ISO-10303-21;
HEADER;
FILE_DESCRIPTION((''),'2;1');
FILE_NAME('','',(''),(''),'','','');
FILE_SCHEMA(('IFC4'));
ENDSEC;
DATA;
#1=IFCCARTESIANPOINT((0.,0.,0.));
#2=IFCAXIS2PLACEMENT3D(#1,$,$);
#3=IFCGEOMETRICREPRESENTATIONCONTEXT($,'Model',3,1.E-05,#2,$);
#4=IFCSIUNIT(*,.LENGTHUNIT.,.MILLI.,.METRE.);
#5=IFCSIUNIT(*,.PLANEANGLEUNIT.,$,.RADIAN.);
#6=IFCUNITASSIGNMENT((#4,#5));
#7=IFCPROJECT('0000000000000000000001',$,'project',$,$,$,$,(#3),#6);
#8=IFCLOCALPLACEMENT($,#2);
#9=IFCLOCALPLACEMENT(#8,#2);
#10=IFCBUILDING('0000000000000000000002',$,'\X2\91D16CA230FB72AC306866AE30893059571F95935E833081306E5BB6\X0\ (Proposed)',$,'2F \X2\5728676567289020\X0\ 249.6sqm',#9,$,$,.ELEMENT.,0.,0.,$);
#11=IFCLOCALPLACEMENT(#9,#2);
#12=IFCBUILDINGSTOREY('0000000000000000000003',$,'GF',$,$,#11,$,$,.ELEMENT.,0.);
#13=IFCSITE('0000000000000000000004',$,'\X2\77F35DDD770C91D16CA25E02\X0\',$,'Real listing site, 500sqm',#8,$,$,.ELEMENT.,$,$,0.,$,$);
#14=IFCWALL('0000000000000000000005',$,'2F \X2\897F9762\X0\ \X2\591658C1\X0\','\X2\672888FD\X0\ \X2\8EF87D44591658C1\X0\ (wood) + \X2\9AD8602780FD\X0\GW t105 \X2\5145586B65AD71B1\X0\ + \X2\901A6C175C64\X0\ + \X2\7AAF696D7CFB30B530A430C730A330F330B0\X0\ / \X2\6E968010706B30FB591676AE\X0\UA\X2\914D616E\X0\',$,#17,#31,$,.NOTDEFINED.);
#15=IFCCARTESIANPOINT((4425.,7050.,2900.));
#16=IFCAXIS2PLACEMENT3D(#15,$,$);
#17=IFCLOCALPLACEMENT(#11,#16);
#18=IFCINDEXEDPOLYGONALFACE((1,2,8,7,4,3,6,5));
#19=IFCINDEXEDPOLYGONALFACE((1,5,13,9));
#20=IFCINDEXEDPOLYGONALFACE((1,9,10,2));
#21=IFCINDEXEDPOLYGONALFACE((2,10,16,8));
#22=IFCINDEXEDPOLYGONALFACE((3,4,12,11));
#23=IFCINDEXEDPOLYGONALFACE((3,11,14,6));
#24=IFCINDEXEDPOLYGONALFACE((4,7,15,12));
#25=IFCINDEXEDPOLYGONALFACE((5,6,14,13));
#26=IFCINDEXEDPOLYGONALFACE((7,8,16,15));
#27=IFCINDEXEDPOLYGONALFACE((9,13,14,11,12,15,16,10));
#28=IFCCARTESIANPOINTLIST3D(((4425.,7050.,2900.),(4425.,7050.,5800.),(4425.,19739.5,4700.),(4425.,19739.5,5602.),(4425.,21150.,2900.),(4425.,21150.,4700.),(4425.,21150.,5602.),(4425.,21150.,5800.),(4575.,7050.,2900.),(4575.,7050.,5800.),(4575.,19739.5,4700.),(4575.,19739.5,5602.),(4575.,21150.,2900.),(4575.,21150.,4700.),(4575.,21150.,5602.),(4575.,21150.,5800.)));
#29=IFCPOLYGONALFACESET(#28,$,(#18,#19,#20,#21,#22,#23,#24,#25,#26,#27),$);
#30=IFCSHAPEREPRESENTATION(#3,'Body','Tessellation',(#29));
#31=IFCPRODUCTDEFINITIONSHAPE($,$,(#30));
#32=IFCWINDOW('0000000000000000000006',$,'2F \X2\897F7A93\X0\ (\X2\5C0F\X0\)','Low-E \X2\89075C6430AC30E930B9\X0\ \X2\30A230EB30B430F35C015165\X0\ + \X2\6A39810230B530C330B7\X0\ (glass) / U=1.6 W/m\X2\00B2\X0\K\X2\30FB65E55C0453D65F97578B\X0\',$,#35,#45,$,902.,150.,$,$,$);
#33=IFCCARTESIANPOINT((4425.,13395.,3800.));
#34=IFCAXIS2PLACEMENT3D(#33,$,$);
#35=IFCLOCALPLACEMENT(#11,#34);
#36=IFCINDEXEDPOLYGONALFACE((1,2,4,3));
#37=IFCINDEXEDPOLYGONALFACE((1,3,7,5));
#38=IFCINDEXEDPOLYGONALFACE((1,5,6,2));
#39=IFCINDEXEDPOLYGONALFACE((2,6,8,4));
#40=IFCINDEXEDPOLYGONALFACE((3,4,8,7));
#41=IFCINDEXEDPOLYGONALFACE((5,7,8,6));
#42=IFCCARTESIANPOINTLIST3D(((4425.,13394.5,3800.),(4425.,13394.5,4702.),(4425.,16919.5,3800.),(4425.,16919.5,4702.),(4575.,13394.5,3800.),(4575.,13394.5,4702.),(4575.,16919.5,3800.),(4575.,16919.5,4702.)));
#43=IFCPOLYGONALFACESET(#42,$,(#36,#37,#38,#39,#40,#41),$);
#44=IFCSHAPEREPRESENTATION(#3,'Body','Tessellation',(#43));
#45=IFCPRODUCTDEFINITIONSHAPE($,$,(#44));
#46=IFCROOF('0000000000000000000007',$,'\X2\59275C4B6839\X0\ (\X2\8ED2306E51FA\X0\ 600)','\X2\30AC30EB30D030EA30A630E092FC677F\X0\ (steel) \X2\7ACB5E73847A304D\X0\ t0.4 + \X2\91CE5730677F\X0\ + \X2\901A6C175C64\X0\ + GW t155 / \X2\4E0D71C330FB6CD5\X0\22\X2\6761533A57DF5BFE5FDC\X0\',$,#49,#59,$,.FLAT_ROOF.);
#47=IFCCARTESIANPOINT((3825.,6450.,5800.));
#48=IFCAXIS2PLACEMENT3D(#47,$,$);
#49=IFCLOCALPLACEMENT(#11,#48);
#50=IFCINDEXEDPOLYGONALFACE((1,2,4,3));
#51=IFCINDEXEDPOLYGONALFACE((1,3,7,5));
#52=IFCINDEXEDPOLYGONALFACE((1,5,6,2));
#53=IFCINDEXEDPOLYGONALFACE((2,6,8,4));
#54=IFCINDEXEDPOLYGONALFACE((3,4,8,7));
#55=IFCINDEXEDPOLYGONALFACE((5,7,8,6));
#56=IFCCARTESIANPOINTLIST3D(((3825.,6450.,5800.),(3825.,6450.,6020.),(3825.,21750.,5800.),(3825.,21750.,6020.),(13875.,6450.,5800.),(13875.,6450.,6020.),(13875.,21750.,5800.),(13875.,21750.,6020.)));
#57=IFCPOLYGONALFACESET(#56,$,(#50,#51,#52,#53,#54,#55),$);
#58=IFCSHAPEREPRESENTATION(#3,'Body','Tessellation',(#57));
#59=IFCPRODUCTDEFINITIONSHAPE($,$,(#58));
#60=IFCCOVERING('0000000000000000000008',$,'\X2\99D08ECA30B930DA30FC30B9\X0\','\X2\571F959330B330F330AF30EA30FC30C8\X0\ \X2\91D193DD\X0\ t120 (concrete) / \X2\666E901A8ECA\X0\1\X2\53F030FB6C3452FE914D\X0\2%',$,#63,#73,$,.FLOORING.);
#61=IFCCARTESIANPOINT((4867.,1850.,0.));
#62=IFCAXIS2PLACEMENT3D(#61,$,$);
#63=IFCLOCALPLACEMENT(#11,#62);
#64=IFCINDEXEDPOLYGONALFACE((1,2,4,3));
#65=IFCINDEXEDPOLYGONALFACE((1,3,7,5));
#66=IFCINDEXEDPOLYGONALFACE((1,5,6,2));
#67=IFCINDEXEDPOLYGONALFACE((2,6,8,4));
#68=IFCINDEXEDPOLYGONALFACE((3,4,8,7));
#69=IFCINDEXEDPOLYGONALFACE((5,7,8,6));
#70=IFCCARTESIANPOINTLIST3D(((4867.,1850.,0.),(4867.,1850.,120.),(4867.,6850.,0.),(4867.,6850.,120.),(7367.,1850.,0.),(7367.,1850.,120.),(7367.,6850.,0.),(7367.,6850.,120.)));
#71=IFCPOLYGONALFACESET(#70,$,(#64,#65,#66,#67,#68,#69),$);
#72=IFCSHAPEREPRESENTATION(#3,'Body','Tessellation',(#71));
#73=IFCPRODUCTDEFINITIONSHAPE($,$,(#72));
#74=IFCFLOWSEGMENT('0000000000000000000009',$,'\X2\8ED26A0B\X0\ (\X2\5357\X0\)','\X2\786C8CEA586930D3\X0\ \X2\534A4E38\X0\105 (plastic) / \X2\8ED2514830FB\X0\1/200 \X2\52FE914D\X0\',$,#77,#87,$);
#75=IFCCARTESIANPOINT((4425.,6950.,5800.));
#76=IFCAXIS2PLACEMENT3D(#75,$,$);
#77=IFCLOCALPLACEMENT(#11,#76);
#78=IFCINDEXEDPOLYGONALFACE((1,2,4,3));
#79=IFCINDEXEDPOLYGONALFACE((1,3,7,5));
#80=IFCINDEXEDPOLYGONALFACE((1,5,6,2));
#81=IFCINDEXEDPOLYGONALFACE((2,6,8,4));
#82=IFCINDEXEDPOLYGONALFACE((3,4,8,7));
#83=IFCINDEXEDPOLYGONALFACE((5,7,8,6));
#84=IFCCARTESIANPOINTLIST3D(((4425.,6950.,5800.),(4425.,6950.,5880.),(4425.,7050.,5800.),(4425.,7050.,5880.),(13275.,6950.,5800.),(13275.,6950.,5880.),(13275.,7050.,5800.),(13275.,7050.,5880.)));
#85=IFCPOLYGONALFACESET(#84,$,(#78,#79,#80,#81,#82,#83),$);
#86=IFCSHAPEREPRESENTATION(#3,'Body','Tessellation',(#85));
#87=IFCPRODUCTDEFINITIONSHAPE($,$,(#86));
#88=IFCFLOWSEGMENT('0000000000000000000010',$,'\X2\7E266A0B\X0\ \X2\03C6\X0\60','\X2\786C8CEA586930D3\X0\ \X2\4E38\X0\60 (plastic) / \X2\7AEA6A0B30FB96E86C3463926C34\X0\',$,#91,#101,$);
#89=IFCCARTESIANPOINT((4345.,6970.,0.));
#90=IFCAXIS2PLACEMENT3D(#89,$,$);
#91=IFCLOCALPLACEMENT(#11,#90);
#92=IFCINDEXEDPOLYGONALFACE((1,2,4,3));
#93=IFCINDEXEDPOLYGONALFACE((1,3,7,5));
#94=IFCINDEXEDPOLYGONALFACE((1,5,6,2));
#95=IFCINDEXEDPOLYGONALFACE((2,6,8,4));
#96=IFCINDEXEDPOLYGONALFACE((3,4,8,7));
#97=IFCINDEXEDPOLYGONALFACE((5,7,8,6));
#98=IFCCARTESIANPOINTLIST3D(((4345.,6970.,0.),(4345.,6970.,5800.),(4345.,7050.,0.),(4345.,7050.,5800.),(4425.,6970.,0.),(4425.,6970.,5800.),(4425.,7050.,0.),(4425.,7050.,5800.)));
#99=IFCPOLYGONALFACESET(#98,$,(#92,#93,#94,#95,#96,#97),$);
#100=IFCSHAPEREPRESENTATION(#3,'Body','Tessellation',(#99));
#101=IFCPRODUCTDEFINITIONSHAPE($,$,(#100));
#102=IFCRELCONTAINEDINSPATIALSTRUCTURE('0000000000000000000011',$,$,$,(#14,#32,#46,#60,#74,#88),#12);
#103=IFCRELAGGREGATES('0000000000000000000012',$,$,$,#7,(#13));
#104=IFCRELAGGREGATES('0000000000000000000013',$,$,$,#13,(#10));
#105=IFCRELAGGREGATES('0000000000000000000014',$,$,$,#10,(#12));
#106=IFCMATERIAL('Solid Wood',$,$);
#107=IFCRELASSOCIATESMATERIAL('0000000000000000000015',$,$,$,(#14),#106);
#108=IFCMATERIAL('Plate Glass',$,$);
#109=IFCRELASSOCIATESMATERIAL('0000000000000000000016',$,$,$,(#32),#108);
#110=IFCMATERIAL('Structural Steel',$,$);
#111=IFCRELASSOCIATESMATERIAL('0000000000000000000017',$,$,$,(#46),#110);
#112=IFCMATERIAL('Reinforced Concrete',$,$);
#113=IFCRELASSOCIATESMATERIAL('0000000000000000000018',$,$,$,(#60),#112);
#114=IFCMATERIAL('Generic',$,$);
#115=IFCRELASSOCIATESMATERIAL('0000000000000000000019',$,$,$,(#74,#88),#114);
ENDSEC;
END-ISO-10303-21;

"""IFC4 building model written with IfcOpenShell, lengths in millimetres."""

from ifc_helpers import new_model, si_unit, frame, frame_2d, origin, place, context, project, spatial, rectangle, extrude, material, element, fill, save


model = new_model("IFC4")

# Units and contexts
model_context = context("Model", 3, precision=1e-05, world=origin())
ifc_project = project(units=[si_unit("LENGTHUNIT", "METRE", prefix="MILLI"), si_unit("PLANEANGLEUNIT", "RADIAN")], contexts=[model_context])

# Site, building, storey
site_placement = place(None, origin())
site = spatial("IfcSite", under=ifc_project, at=site_placement, Name="石川県金沢市", ObjectType="Real listing site, 500sqm", CompositionType="ELEMENT", RefElevation=0.0)
building_placement = place(site_placement, origin())
building = spatial("IfcBuilding", under=site, at=building_placement, Name="金沢・犬と暮らす土間広めの家 (Proposed)", ObjectType="2F 在来木造 249.6sqm", CompositionType="ELEMENT", ElevationOfRefHeight=0.0, ElevationOfTerrain=0.0)
storey_placement = place(building_placement, origin())
storey = spatial("IfcBuildingStorey", under=building, at=storey_placement, Name="GF", CompositionType="ELEMENT", Elevation=0.0)

# Shared definitions
ifc_material_1 = material(Name="Solid Wood")

# Shared definitions
ifc_material_2 = material(Name="Reinforced Concrete")

# Shared definitions
ifc_material_3 = material(Name="Plate Glass")

# Wall, opening, window
wall_1_placement = place(storey_placement, frame((4425.0, 7050.0, 2900.0)))
wall_1 = element("IfcWall", 1, at=wall_1_placement, inside=storey, material=ifc_material_1, Name="2F 西面 外壁", Description="木製 軸組外壁 (wood) + 高性能GW t105 充填断熱 + 通気層 + 窯業系サイディング / 準耐火・外皮UA配慮", PredefinedType="NOTDEFINED", context=model_context, shape_type="SweptSolid", body=[
    extrude(rectangle(XDim=150.0, YDim=14100.0, at=frame_2d((75.0, 7050.0))), frame((4425.0, 7050.0, 2900.0)), (0.0, 0.0, 1.0), 2900.0),
])
opening_1_placement = place(storey_placement, frame((4425.0, 13395.0, 3800.0)))
opening_1 = element("IfcOpeningElement", 2, at=opening_1_placement, cuts=wall_1, PredefinedType="NOTDEFINED", context=model_context, shape_type="SweptSolid", body=[
    extrude(rectangle(XDim=150.0, YDim=3525.0, at=frame_2d((75.0, 1762.0))), frame((4425.0, 13395.0, 3800.0)), (0.0, 0.0, 1.0), 902.0),
])
window_1_placement = place(storey_placement, frame((4425.0, 13395.0, 3800.0)))
window_1 = element("IfcWindow", 3, at=window_1_placement, inside=storey, material=ifc_material_3, Name="2F 西窓 (小)", Description="Low-E 複層ガラス アルゴン封入 + 樹脂サッシ (glass) / U=1.6 W/m²K・日射取得型", OverallHeight=902.0, OverallWidth=150.0, context=model_context, shape_type="SweptSolid", body=[
    extrude(rectangle(XDim=150.0, YDim=3525.0, at=frame_2d((75.0, 1762.0))), frame((4425.0, 13395.0, 3800.0)), (0.0, 0.0, 1.0), 902.0),
])
fill(opening_1, window_1)

# Roof
ifc_material_4 = material(Name="Structural Steel")
roof_placement = place(storey_placement, frame((3825.0, 6450.0, 5800.0)))
element("IfcRoof", 4, at=roof_placement, inside=storey, material=ifc_material_4, Name="大屋根 (軒の出 600)", Description="ガルバリウム鋼板 (steel) 立平葺き t0.4 + 野地板 + 通気層 + GW t155 / 不燃・法22条区域対応", PredefinedType="FLAT_ROOF", context=model_context, shape_type="SweptSolid", body=[
    extrude(rectangle(XDim=10050.0, YDim=15300.0, at=frame_2d((5025.0, 7650.0))), frame((3825.0, 6450.0, 5800.0)), (0.0, 0.0, 1.0), 220.0),
])

# Covering
covering_placement = place(storey_placement, frame((4867.0, 1850.0, 0.0)))
element("IfcCovering", 5, at=covering_placement, inside=storey, material=ifc_material_2, Name="駐車スペース", Description="土間コンクリート 金鏝 t120 (concrete) / 普通車1台・水勾配2%", PredefinedType="FLOORING", context=model_context, shape_type="SweptSolid", body=[
    extrude(rectangle(XDim=2500.0, YDim=5000.0, at=frame_2d((1250.0, 2500.0))), frame((4867.0, 1850.0, 0.0)), (0.0, 0.0, 1.0), 120.0),
])

# Flow segments
ifc_material_5 = material(Name="Generic")
flow_segment_1_placement = place(storey_placement, frame((4425.0, 6950.0, 5800.0)))
element("IfcFlowSegment", 6, at=flow_segment_1_placement, inside=storey, material=ifc_material_5, Name="軒樋 (南)", Description="硬質塩ビ 半丸105 (plastic) / 軒先・1/200 勾配", context=model_context, shape_type="SweptSolid", body=[
    extrude(rectangle(XDim=8850.0, YDim=100.0, at=frame_2d((4425.0, 50.0))), frame((4425.0, 6950.0, 5800.0)), (0.0, 0.0, 1.0), 80.0),
])
flow_segment_2_placement = place(storey_placement, frame((4345.0, 6970.0, 0.0)))
element("IfcFlowSegment", 7, at=flow_segment_2_placement, inside=storey, material=ifc_material_5, Name="縦樋 φ60", Description="硬質塩ビ 丸60 (plastic) / 竪樋・雨水排水", context=model_context, shape_type="SweptSolid", body=[
    extrude(rectangle(XDim=80.0, YDim=80.0, at=frame_2d((40.0, 40.0))), frame((4345.0, 6970.0, 0.0)), (0.0, 0.0, 1.0), 5800.0),
])

save(model, "model.ifc")
